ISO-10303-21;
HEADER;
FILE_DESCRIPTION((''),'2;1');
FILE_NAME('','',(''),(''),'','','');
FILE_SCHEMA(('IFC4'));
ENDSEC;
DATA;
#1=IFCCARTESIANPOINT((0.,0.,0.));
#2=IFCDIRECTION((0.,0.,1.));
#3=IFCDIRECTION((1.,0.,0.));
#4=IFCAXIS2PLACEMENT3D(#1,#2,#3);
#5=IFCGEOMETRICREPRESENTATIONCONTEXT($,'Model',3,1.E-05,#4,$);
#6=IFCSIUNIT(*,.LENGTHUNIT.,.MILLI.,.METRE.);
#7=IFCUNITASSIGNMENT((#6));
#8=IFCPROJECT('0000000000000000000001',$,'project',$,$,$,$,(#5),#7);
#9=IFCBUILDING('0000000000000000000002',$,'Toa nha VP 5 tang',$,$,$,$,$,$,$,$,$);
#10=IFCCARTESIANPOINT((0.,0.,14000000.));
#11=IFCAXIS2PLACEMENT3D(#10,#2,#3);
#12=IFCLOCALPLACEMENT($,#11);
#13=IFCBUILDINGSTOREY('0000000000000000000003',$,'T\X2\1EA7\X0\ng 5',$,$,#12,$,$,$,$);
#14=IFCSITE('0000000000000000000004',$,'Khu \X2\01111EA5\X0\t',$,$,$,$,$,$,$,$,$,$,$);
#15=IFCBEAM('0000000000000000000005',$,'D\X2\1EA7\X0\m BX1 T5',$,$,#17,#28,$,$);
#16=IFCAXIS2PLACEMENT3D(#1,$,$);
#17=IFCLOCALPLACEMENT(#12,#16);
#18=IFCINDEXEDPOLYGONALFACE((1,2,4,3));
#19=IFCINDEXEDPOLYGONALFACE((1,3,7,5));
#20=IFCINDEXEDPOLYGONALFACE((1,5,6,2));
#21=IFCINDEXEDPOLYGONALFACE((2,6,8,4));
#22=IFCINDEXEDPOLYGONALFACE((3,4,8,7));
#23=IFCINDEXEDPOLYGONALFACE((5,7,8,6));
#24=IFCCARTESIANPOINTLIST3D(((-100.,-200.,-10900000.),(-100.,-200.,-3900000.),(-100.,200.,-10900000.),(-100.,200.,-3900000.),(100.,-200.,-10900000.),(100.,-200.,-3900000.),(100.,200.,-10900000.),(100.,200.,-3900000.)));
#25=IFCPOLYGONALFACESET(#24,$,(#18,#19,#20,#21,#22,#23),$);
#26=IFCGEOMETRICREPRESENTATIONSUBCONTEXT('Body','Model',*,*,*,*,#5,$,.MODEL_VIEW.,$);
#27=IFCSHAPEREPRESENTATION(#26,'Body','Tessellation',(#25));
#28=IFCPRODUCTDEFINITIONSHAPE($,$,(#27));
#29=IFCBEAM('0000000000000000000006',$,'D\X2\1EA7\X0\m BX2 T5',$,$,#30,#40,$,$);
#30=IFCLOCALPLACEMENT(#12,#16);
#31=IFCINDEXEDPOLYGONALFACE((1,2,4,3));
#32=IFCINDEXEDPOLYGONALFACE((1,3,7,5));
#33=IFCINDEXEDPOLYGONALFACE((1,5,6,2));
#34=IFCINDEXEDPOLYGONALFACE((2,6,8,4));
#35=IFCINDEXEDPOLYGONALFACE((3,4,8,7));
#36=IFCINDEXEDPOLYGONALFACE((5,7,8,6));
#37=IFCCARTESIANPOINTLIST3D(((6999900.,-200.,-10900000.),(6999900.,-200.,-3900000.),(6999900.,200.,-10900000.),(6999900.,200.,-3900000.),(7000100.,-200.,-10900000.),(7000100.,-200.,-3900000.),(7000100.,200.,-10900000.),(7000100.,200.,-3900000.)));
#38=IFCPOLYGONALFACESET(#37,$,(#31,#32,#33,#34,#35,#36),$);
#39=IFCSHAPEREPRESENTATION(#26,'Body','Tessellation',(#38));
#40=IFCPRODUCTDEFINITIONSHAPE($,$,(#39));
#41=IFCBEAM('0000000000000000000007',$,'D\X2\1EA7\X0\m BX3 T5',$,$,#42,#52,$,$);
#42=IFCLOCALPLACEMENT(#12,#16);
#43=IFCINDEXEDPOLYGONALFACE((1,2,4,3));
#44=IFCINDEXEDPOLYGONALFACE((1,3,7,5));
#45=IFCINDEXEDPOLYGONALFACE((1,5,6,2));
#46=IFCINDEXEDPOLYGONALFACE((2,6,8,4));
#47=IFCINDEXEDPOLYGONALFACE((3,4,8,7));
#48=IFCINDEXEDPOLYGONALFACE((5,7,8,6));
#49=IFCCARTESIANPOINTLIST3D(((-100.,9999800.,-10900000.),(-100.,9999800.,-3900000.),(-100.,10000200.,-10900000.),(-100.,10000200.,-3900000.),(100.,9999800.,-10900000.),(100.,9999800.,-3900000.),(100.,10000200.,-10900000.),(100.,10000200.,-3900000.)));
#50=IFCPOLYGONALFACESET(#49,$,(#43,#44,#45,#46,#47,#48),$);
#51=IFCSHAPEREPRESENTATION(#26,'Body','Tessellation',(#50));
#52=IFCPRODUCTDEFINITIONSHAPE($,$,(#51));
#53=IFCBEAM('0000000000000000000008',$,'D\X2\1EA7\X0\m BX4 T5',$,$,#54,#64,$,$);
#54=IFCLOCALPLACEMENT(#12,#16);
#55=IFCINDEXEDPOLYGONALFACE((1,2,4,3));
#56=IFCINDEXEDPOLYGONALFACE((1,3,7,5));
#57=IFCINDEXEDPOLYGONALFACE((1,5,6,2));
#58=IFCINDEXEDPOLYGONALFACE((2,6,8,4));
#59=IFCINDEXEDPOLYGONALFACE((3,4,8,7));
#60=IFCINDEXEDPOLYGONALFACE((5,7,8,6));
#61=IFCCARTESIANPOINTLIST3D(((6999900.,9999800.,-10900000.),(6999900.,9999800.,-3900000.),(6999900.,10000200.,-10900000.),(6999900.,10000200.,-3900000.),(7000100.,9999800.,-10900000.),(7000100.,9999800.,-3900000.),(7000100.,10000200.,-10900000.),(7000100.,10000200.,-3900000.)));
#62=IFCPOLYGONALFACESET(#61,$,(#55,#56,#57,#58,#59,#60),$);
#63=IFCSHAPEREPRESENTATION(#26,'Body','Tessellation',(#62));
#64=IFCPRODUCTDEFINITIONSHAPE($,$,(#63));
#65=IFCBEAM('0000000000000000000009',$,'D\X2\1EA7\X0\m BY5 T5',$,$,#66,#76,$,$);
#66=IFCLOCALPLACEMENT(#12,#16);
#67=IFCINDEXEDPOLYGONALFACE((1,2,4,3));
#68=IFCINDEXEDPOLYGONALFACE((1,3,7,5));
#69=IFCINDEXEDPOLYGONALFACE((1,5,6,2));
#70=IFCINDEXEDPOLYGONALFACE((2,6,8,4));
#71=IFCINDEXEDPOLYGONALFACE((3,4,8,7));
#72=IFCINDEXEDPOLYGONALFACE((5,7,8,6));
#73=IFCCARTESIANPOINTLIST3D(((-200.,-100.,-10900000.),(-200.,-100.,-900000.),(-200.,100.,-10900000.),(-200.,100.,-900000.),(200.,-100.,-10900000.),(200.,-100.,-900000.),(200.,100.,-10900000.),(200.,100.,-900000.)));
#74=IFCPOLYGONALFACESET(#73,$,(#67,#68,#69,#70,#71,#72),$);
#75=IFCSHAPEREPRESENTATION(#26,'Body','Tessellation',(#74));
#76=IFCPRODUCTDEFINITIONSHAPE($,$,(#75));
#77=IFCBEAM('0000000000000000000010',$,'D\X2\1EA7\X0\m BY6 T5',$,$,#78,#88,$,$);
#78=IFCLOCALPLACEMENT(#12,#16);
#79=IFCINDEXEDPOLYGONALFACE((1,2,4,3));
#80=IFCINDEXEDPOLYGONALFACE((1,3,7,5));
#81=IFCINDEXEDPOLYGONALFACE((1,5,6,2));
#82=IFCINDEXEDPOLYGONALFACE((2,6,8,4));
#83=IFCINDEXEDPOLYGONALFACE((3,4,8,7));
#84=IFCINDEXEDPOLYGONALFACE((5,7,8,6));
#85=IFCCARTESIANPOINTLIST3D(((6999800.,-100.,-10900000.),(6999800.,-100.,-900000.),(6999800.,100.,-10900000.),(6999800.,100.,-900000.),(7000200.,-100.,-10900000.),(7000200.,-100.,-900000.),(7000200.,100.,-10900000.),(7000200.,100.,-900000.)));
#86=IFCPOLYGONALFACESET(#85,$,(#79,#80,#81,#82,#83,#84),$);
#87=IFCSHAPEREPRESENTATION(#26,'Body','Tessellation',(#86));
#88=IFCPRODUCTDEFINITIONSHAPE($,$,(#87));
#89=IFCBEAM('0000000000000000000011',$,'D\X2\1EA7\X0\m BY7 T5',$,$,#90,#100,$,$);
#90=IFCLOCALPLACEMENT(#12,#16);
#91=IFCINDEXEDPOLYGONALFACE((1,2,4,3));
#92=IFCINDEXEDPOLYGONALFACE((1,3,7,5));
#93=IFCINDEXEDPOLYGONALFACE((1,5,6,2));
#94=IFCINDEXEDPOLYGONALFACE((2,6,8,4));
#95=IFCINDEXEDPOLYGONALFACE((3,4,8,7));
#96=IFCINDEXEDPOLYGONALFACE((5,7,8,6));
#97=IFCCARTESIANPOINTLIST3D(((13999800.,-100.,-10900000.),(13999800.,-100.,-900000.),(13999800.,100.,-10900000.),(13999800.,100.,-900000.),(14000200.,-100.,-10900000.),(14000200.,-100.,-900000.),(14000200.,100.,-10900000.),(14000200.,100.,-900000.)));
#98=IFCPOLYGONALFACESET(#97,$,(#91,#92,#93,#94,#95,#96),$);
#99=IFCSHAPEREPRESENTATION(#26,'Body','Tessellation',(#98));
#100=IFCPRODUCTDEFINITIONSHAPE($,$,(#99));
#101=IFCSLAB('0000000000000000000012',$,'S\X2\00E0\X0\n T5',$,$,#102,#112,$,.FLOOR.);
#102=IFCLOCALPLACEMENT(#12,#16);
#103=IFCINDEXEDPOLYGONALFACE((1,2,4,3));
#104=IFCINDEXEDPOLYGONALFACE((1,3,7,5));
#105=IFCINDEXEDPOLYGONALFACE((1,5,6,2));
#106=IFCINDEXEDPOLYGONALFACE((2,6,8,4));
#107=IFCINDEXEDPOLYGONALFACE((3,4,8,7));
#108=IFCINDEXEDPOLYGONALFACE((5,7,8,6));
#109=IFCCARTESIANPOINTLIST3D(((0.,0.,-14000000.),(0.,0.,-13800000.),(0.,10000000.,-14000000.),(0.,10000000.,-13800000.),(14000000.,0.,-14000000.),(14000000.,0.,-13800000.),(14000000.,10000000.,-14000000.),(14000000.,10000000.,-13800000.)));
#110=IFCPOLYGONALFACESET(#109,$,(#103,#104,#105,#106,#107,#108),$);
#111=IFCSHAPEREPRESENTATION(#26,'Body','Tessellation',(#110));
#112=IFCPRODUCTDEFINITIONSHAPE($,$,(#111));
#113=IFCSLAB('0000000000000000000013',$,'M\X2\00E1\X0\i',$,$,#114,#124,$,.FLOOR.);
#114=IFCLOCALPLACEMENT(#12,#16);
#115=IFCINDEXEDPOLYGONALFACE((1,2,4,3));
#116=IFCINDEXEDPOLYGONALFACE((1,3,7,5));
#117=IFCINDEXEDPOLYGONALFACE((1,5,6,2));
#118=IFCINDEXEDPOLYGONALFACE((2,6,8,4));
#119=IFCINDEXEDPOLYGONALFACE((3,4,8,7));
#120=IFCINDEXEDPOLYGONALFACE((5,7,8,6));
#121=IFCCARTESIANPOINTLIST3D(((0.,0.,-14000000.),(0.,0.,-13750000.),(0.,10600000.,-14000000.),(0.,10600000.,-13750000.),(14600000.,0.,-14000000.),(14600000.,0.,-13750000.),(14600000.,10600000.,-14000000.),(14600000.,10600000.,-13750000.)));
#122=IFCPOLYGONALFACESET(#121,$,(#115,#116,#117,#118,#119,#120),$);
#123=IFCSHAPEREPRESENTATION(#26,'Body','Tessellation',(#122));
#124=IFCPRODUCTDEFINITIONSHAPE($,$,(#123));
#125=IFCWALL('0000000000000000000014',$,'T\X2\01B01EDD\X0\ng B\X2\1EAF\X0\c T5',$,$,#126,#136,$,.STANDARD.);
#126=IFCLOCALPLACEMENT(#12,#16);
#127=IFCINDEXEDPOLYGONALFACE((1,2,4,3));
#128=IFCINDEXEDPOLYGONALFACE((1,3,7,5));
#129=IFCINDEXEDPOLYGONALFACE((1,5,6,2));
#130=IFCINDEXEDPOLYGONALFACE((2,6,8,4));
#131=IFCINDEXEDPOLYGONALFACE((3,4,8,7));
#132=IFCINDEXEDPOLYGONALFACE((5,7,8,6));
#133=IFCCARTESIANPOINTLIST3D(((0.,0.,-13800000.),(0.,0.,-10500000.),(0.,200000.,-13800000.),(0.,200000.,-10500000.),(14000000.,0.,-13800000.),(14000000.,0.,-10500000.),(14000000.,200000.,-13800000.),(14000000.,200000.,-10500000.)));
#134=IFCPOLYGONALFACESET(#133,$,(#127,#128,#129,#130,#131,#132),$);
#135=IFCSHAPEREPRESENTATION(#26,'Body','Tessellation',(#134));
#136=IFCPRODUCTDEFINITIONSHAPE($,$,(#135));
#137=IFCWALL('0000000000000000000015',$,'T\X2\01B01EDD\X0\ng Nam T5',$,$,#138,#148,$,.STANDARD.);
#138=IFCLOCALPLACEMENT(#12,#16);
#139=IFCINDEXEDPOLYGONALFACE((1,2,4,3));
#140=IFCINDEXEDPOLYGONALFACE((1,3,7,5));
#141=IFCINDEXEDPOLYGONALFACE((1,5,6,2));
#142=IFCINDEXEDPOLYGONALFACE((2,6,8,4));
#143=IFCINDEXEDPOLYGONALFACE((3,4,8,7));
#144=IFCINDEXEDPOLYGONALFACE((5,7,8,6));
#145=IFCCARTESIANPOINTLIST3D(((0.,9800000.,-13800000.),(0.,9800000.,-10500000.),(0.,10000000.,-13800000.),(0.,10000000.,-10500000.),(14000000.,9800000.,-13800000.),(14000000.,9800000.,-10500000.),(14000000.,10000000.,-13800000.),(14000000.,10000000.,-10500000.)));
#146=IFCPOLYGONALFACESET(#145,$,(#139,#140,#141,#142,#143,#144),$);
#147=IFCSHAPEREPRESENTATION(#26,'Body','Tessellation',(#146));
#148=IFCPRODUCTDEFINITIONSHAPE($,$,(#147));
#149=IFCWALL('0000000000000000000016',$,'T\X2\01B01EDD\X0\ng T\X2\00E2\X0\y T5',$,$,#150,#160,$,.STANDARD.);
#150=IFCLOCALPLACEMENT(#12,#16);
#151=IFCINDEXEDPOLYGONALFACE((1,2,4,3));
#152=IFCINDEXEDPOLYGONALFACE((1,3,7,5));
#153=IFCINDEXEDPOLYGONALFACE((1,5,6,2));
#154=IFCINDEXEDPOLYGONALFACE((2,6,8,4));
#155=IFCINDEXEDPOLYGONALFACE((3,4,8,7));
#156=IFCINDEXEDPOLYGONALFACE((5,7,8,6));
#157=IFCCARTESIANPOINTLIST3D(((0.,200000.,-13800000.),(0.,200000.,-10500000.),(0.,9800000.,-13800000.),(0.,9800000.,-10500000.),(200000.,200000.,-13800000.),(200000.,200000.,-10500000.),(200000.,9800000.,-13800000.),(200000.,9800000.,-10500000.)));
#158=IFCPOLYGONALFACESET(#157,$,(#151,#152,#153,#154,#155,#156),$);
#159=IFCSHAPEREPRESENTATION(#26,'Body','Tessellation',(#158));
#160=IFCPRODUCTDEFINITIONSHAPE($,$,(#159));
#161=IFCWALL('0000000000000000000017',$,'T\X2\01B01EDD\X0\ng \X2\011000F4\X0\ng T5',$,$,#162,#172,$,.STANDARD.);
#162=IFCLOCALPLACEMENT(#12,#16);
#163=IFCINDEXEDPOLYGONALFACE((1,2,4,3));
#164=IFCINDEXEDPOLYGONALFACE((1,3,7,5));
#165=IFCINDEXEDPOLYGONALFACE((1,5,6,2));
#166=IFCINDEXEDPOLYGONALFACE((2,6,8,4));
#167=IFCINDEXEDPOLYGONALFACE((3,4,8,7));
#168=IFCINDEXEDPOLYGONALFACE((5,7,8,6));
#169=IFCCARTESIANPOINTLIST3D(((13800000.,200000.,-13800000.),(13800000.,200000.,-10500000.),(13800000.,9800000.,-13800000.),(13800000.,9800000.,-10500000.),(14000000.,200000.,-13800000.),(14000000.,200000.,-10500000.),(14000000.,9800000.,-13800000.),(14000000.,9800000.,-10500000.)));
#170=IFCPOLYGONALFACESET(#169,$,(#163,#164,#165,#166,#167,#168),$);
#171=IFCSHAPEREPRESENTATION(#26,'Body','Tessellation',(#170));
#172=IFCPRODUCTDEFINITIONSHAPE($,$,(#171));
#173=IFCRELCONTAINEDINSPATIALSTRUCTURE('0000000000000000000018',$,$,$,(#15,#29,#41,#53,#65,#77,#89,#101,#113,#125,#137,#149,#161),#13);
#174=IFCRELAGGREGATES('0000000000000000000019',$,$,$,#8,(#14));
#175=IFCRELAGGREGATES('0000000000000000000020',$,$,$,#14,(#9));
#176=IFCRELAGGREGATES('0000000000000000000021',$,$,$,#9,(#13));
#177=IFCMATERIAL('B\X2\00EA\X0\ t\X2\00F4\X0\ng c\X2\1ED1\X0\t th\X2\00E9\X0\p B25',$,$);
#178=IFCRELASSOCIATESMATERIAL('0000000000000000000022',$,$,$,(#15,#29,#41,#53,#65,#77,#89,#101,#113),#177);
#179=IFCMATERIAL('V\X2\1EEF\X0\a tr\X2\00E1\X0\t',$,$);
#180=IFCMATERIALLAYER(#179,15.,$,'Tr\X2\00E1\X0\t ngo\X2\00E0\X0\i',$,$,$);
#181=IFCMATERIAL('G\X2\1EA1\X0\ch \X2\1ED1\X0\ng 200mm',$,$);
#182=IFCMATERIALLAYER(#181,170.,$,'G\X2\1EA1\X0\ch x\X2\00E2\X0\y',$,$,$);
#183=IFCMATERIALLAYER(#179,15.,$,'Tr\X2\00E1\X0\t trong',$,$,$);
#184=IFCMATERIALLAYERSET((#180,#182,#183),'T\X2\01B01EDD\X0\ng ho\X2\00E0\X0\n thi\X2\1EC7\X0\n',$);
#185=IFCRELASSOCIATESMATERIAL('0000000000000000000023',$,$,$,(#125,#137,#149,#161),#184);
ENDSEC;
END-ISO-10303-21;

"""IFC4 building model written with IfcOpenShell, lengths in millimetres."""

from ifc_helpers import new_model, entity, si_unit, frame, origin_with_axes, place, context, subcontext, project, spatial, indexed_curve, outline, extrude, material, layer, layer_set, layer_usage, element, save


model = new_model("IFC4")

# Units and contexts
model_context = context("Model", 3, precision=1e-05, world=origin_with_axes())
body_context = subcontext(model_context, "Body", "Model", "MODEL_VIEW")
ifc_project = project(units=[si_unit("LENGTHUNIT", "METRE", prefix="MILLI")], contexts=[model_context])

# Site, building, storey
site = spatial("IfcSite", under=ifc_project, Name="Khu đất")
building = spatial("IfcBuilding", under=site, Name="Toa nha VP 5 tang")
storey_placement = place(None, frame((0.0, 0.0, 14000000.0), z_axis=(0.0, 0.0, 1.0), x_axis=(1.0, 0.0, 0.0)))
storey = spatial("IfcBuildingStorey", under=building, at=storey_placement, Name="Tầng 5")

# Beams
ifc_material_1 = material(Name="Bê tông cốt thép B25")
for number, where, z_axis, x_axis, name in (
    (1, (0.0, 0.0, -10900000.0), (0.0, 0.0, 1.0), (1.0, 0.0, 0.0), "Dầm BX1 T5"),
    (2, (7000000.0, 0.0, -10900000.0), (0.0, 0.0, 1.0), (1.0, 0.0, 0.0), "Dầm BX2 T5"),
    (3, (0.0, 10000000.0, -10900000.0), (0.0, 0.0, 1.0), (1.0, 0.0, 0.0), "Dầm BX3 T5"),
    (4, (7000000.0, 10000000.0, -10900000.0), (0.0, 0.0, 1.0), (1.0, 0.0, 0.0), "Dầm BX4 T5"),
):
    element("IfcBeam", number, at=place(storey_placement, frame(where, z_axis=z_axis, x_axis=x_axis)), inside=storey, material=ifc_material_1, Name=name, context=body_context, shape_type="SweptSolid", body=[
        extrude(entity("IfcRectangleProfileDef", None, None, None, 200.0, 400.0), origin_with_axes(), (0.0, 0.0, 1.0), 7000000.0),
    ])
for number, where, z_axis, x_axis, name in (
    (5, (0.0, 0.0, -10900000.0), (0.0, 0.0, 1.0), (0.0, 1.0, 0.0), "Dầm BY5 T5"),
    (6, (7000000.0, 0.0, -10900000.0), (0.0, 0.0, 1.0), (0.0, 1.0, 0.0), "Dầm BY6 T5"),
    (7, (14000000.0, 0.0, -10900000.0), (0.0, 0.0, 1.0), (0.0, 1.0, 0.0), "Dầm BY7 T5"),
):
    element("IfcBeam", number, at=place(storey_placement, frame(where, z_axis=z_axis, x_axis=x_axis)), inside=storey, material=ifc_material_1, Name=name, context=body_context, shape_type="SweptSolid", body=[
        extrude(entity("IfcRectangleProfileDef", None, None, None, 200.0, 400.0), origin_with_axes(), (0.0, 0.0, 1.0), 10000000.0),
    ])

# Slabs
slab_1_placement = place(storey_placement, frame((0.0, 0.0, -14000000.0), z_axis=(0.0, 0.0, 1.0), x_axis=(1.0, 0.0, 0.0)))
element("IfcSlab", 8, at=slab_1_placement, inside=storey, material=ifc_material_1, Name="Sàn T5", PredefinedType="FLOOR", context=body_context, shape_type="SweptSolid", body=[
    extrude(outline(indexed_curve([(0.0, 0.0), (14000000.0, 0.0), (14000000.0, 10000000.0), (0.0, 10000000.0), (0.0, 0.0)])), None, (0.0, 0.0, 1.0), 200000.0),
])
slab_2_placement = place(storey_placement, frame((0.0, 0.0, -14000000.0), z_axis=(0.0, 0.0, 1.0), x_axis=(1.0, 0.0, 0.0)))
element("IfcSlab", 9, at=slab_2_placement, inside=storey, material=ifc_material_1, Name="Mái", PredefinedType="FLOOR", context=body_context, shape_type="SweptSolid", body=[
    extrude(outline(indexed_curve([(0.0, 0.0), (14600000.0, 0.0), (14600000.0, 10600000.0), (0.0, 10600000.0), (0.0, 0.0)])), None, (0.0, 0.0, 1.0), 250000.0),
])

# Walls
ifc_material_2 = material(Name="Vữa trát")
ifc_layer_1 = layer(ifc_material_2, 15.0, Name="Trát ngoài")
ifc_material_3 = material(Name="Gạch ống 200mm")
ifc_layer_2 = layer(ifc_material_3, 170.0, Name="Gạch xây")
ifc_layer_3 = layer(ifc_material_2, 15.0, Name="Trát trong")
ifc_layer_set = layer_set([ifc_layer_1, ifc_layer_2, ifc_layer_3], Name="Tường hoàn thiện")
ifc_layer_usage_1 = layer_usage(ifc_layer_set, "AXIS2", "POSITIVE", 0.0)
wall_1_placement = place(storey_placement, frame((0.0, 0.0, -13800000.0), z_axis=(0.0, 0.0, 1.0), x_axis=(1.0, 0.0, 0.0)))
element("IfcWall", 10, at=wall_1_placement, inside=storey, material=ifc_layer_usage_1, Name="Tường Bắc T5", PredefinedType="STANDARD", context=body_context, shape_type="SweptSolid", body=[
    extrude(outline(indexed_curve([(0.0, 0.0), (0.0, 200000.0), (14000000.0, 200000.0), (14000000.0, 0.0), (0.0, 0.0)], self_intersect=False)), origin_with_axes(), (0.0, 0.0, 1.0), 3300000.0),
])
ifc_layer_usage_2 = layer_usage(ifc_layer_set, "AXIS2", "POSITIVE", 0.0)
wall_2_placement = place(storey_placement, frame((0.0, 9800000.0, -13800000.0), z_axis=(0.0, 0.0, 1.0), x_axis=(1.0, 0.0, 0.0)))
element("IfcWall", 11, at=wall_2_placement, inside=storey, material=ifc_layer_usage_2, Name="Tường Nam T5", PredefinedType="STANDARD", context=body_context, shape_type="SweptSolid", body=[
    extrude(outline(indexed_curve([(0.0, 0.0), (0.0, 200000.0), (14000000.0, 200000.0), (14000000.0, 0.0), (0.0, 0.0)], self_intersect=False)), origin_with_axes(), (0.0, 0.0, 1.0), 3300000.0),
])
ifc_layer_usage_3 = layer_usage(ifc_layer_set, "AXIS2", "POSITIVE", 0.0)
wall_3_placement = place(storey_placement, frame((0.0, 200000.0, -13800000.0), z_axis=(0.0, 0.0, 1.0), x_axis=(1.0, 0.0, 0.0)))
element("IfcWall", 12, at=wall_3_placement, inside=storey, material=ifc_layer_usage_3, Name="Tường Tây T5", PredefinedType="STANDARD", context=body_context, shape_type="SweptSolid", body=[
    extrude(outline(indexed_curve([(0.0, 0.0), (0.0, 9600000.0), (200000.0, 9600000.0), (200000.0, 0.0), (0.0, 0.0)], self_intersect=False)), origin_with_axes(), (0.0, 0.0, 1.0), 3300000.0),
])
ifc_layer_usage_4 = layer_usage(ifc_layer_set, "AXIS2", "POSITIVE", 0.0)
wall_4_placement = place(storey_placement, frame((13800000.0, 200000.0, -13800000.0), z_axis=(0.0, 0.0, 1.0), x_axis=(1.0, 0.0, 0.0)))
element("IfcWall", 13, at=wall_4_placement, inside=storey, material=ifc_layer_usage_4, Name="Tường Đông T5", PredefinedType="STANDARD", context=body_context, shape_type="SweptSolid", body=[
    extrude(outline(indexed_curve([(0.0, 0.0), (0.0, 9600000.0), (200000.0, 9600000.0), (200000.0, 0.0), (0.0, 0.0)], self_intersect=False)), origin_with_axes(), (0.0, 0.0, 1.0), 3300000.0),
])

save(model, "model.ifc")
